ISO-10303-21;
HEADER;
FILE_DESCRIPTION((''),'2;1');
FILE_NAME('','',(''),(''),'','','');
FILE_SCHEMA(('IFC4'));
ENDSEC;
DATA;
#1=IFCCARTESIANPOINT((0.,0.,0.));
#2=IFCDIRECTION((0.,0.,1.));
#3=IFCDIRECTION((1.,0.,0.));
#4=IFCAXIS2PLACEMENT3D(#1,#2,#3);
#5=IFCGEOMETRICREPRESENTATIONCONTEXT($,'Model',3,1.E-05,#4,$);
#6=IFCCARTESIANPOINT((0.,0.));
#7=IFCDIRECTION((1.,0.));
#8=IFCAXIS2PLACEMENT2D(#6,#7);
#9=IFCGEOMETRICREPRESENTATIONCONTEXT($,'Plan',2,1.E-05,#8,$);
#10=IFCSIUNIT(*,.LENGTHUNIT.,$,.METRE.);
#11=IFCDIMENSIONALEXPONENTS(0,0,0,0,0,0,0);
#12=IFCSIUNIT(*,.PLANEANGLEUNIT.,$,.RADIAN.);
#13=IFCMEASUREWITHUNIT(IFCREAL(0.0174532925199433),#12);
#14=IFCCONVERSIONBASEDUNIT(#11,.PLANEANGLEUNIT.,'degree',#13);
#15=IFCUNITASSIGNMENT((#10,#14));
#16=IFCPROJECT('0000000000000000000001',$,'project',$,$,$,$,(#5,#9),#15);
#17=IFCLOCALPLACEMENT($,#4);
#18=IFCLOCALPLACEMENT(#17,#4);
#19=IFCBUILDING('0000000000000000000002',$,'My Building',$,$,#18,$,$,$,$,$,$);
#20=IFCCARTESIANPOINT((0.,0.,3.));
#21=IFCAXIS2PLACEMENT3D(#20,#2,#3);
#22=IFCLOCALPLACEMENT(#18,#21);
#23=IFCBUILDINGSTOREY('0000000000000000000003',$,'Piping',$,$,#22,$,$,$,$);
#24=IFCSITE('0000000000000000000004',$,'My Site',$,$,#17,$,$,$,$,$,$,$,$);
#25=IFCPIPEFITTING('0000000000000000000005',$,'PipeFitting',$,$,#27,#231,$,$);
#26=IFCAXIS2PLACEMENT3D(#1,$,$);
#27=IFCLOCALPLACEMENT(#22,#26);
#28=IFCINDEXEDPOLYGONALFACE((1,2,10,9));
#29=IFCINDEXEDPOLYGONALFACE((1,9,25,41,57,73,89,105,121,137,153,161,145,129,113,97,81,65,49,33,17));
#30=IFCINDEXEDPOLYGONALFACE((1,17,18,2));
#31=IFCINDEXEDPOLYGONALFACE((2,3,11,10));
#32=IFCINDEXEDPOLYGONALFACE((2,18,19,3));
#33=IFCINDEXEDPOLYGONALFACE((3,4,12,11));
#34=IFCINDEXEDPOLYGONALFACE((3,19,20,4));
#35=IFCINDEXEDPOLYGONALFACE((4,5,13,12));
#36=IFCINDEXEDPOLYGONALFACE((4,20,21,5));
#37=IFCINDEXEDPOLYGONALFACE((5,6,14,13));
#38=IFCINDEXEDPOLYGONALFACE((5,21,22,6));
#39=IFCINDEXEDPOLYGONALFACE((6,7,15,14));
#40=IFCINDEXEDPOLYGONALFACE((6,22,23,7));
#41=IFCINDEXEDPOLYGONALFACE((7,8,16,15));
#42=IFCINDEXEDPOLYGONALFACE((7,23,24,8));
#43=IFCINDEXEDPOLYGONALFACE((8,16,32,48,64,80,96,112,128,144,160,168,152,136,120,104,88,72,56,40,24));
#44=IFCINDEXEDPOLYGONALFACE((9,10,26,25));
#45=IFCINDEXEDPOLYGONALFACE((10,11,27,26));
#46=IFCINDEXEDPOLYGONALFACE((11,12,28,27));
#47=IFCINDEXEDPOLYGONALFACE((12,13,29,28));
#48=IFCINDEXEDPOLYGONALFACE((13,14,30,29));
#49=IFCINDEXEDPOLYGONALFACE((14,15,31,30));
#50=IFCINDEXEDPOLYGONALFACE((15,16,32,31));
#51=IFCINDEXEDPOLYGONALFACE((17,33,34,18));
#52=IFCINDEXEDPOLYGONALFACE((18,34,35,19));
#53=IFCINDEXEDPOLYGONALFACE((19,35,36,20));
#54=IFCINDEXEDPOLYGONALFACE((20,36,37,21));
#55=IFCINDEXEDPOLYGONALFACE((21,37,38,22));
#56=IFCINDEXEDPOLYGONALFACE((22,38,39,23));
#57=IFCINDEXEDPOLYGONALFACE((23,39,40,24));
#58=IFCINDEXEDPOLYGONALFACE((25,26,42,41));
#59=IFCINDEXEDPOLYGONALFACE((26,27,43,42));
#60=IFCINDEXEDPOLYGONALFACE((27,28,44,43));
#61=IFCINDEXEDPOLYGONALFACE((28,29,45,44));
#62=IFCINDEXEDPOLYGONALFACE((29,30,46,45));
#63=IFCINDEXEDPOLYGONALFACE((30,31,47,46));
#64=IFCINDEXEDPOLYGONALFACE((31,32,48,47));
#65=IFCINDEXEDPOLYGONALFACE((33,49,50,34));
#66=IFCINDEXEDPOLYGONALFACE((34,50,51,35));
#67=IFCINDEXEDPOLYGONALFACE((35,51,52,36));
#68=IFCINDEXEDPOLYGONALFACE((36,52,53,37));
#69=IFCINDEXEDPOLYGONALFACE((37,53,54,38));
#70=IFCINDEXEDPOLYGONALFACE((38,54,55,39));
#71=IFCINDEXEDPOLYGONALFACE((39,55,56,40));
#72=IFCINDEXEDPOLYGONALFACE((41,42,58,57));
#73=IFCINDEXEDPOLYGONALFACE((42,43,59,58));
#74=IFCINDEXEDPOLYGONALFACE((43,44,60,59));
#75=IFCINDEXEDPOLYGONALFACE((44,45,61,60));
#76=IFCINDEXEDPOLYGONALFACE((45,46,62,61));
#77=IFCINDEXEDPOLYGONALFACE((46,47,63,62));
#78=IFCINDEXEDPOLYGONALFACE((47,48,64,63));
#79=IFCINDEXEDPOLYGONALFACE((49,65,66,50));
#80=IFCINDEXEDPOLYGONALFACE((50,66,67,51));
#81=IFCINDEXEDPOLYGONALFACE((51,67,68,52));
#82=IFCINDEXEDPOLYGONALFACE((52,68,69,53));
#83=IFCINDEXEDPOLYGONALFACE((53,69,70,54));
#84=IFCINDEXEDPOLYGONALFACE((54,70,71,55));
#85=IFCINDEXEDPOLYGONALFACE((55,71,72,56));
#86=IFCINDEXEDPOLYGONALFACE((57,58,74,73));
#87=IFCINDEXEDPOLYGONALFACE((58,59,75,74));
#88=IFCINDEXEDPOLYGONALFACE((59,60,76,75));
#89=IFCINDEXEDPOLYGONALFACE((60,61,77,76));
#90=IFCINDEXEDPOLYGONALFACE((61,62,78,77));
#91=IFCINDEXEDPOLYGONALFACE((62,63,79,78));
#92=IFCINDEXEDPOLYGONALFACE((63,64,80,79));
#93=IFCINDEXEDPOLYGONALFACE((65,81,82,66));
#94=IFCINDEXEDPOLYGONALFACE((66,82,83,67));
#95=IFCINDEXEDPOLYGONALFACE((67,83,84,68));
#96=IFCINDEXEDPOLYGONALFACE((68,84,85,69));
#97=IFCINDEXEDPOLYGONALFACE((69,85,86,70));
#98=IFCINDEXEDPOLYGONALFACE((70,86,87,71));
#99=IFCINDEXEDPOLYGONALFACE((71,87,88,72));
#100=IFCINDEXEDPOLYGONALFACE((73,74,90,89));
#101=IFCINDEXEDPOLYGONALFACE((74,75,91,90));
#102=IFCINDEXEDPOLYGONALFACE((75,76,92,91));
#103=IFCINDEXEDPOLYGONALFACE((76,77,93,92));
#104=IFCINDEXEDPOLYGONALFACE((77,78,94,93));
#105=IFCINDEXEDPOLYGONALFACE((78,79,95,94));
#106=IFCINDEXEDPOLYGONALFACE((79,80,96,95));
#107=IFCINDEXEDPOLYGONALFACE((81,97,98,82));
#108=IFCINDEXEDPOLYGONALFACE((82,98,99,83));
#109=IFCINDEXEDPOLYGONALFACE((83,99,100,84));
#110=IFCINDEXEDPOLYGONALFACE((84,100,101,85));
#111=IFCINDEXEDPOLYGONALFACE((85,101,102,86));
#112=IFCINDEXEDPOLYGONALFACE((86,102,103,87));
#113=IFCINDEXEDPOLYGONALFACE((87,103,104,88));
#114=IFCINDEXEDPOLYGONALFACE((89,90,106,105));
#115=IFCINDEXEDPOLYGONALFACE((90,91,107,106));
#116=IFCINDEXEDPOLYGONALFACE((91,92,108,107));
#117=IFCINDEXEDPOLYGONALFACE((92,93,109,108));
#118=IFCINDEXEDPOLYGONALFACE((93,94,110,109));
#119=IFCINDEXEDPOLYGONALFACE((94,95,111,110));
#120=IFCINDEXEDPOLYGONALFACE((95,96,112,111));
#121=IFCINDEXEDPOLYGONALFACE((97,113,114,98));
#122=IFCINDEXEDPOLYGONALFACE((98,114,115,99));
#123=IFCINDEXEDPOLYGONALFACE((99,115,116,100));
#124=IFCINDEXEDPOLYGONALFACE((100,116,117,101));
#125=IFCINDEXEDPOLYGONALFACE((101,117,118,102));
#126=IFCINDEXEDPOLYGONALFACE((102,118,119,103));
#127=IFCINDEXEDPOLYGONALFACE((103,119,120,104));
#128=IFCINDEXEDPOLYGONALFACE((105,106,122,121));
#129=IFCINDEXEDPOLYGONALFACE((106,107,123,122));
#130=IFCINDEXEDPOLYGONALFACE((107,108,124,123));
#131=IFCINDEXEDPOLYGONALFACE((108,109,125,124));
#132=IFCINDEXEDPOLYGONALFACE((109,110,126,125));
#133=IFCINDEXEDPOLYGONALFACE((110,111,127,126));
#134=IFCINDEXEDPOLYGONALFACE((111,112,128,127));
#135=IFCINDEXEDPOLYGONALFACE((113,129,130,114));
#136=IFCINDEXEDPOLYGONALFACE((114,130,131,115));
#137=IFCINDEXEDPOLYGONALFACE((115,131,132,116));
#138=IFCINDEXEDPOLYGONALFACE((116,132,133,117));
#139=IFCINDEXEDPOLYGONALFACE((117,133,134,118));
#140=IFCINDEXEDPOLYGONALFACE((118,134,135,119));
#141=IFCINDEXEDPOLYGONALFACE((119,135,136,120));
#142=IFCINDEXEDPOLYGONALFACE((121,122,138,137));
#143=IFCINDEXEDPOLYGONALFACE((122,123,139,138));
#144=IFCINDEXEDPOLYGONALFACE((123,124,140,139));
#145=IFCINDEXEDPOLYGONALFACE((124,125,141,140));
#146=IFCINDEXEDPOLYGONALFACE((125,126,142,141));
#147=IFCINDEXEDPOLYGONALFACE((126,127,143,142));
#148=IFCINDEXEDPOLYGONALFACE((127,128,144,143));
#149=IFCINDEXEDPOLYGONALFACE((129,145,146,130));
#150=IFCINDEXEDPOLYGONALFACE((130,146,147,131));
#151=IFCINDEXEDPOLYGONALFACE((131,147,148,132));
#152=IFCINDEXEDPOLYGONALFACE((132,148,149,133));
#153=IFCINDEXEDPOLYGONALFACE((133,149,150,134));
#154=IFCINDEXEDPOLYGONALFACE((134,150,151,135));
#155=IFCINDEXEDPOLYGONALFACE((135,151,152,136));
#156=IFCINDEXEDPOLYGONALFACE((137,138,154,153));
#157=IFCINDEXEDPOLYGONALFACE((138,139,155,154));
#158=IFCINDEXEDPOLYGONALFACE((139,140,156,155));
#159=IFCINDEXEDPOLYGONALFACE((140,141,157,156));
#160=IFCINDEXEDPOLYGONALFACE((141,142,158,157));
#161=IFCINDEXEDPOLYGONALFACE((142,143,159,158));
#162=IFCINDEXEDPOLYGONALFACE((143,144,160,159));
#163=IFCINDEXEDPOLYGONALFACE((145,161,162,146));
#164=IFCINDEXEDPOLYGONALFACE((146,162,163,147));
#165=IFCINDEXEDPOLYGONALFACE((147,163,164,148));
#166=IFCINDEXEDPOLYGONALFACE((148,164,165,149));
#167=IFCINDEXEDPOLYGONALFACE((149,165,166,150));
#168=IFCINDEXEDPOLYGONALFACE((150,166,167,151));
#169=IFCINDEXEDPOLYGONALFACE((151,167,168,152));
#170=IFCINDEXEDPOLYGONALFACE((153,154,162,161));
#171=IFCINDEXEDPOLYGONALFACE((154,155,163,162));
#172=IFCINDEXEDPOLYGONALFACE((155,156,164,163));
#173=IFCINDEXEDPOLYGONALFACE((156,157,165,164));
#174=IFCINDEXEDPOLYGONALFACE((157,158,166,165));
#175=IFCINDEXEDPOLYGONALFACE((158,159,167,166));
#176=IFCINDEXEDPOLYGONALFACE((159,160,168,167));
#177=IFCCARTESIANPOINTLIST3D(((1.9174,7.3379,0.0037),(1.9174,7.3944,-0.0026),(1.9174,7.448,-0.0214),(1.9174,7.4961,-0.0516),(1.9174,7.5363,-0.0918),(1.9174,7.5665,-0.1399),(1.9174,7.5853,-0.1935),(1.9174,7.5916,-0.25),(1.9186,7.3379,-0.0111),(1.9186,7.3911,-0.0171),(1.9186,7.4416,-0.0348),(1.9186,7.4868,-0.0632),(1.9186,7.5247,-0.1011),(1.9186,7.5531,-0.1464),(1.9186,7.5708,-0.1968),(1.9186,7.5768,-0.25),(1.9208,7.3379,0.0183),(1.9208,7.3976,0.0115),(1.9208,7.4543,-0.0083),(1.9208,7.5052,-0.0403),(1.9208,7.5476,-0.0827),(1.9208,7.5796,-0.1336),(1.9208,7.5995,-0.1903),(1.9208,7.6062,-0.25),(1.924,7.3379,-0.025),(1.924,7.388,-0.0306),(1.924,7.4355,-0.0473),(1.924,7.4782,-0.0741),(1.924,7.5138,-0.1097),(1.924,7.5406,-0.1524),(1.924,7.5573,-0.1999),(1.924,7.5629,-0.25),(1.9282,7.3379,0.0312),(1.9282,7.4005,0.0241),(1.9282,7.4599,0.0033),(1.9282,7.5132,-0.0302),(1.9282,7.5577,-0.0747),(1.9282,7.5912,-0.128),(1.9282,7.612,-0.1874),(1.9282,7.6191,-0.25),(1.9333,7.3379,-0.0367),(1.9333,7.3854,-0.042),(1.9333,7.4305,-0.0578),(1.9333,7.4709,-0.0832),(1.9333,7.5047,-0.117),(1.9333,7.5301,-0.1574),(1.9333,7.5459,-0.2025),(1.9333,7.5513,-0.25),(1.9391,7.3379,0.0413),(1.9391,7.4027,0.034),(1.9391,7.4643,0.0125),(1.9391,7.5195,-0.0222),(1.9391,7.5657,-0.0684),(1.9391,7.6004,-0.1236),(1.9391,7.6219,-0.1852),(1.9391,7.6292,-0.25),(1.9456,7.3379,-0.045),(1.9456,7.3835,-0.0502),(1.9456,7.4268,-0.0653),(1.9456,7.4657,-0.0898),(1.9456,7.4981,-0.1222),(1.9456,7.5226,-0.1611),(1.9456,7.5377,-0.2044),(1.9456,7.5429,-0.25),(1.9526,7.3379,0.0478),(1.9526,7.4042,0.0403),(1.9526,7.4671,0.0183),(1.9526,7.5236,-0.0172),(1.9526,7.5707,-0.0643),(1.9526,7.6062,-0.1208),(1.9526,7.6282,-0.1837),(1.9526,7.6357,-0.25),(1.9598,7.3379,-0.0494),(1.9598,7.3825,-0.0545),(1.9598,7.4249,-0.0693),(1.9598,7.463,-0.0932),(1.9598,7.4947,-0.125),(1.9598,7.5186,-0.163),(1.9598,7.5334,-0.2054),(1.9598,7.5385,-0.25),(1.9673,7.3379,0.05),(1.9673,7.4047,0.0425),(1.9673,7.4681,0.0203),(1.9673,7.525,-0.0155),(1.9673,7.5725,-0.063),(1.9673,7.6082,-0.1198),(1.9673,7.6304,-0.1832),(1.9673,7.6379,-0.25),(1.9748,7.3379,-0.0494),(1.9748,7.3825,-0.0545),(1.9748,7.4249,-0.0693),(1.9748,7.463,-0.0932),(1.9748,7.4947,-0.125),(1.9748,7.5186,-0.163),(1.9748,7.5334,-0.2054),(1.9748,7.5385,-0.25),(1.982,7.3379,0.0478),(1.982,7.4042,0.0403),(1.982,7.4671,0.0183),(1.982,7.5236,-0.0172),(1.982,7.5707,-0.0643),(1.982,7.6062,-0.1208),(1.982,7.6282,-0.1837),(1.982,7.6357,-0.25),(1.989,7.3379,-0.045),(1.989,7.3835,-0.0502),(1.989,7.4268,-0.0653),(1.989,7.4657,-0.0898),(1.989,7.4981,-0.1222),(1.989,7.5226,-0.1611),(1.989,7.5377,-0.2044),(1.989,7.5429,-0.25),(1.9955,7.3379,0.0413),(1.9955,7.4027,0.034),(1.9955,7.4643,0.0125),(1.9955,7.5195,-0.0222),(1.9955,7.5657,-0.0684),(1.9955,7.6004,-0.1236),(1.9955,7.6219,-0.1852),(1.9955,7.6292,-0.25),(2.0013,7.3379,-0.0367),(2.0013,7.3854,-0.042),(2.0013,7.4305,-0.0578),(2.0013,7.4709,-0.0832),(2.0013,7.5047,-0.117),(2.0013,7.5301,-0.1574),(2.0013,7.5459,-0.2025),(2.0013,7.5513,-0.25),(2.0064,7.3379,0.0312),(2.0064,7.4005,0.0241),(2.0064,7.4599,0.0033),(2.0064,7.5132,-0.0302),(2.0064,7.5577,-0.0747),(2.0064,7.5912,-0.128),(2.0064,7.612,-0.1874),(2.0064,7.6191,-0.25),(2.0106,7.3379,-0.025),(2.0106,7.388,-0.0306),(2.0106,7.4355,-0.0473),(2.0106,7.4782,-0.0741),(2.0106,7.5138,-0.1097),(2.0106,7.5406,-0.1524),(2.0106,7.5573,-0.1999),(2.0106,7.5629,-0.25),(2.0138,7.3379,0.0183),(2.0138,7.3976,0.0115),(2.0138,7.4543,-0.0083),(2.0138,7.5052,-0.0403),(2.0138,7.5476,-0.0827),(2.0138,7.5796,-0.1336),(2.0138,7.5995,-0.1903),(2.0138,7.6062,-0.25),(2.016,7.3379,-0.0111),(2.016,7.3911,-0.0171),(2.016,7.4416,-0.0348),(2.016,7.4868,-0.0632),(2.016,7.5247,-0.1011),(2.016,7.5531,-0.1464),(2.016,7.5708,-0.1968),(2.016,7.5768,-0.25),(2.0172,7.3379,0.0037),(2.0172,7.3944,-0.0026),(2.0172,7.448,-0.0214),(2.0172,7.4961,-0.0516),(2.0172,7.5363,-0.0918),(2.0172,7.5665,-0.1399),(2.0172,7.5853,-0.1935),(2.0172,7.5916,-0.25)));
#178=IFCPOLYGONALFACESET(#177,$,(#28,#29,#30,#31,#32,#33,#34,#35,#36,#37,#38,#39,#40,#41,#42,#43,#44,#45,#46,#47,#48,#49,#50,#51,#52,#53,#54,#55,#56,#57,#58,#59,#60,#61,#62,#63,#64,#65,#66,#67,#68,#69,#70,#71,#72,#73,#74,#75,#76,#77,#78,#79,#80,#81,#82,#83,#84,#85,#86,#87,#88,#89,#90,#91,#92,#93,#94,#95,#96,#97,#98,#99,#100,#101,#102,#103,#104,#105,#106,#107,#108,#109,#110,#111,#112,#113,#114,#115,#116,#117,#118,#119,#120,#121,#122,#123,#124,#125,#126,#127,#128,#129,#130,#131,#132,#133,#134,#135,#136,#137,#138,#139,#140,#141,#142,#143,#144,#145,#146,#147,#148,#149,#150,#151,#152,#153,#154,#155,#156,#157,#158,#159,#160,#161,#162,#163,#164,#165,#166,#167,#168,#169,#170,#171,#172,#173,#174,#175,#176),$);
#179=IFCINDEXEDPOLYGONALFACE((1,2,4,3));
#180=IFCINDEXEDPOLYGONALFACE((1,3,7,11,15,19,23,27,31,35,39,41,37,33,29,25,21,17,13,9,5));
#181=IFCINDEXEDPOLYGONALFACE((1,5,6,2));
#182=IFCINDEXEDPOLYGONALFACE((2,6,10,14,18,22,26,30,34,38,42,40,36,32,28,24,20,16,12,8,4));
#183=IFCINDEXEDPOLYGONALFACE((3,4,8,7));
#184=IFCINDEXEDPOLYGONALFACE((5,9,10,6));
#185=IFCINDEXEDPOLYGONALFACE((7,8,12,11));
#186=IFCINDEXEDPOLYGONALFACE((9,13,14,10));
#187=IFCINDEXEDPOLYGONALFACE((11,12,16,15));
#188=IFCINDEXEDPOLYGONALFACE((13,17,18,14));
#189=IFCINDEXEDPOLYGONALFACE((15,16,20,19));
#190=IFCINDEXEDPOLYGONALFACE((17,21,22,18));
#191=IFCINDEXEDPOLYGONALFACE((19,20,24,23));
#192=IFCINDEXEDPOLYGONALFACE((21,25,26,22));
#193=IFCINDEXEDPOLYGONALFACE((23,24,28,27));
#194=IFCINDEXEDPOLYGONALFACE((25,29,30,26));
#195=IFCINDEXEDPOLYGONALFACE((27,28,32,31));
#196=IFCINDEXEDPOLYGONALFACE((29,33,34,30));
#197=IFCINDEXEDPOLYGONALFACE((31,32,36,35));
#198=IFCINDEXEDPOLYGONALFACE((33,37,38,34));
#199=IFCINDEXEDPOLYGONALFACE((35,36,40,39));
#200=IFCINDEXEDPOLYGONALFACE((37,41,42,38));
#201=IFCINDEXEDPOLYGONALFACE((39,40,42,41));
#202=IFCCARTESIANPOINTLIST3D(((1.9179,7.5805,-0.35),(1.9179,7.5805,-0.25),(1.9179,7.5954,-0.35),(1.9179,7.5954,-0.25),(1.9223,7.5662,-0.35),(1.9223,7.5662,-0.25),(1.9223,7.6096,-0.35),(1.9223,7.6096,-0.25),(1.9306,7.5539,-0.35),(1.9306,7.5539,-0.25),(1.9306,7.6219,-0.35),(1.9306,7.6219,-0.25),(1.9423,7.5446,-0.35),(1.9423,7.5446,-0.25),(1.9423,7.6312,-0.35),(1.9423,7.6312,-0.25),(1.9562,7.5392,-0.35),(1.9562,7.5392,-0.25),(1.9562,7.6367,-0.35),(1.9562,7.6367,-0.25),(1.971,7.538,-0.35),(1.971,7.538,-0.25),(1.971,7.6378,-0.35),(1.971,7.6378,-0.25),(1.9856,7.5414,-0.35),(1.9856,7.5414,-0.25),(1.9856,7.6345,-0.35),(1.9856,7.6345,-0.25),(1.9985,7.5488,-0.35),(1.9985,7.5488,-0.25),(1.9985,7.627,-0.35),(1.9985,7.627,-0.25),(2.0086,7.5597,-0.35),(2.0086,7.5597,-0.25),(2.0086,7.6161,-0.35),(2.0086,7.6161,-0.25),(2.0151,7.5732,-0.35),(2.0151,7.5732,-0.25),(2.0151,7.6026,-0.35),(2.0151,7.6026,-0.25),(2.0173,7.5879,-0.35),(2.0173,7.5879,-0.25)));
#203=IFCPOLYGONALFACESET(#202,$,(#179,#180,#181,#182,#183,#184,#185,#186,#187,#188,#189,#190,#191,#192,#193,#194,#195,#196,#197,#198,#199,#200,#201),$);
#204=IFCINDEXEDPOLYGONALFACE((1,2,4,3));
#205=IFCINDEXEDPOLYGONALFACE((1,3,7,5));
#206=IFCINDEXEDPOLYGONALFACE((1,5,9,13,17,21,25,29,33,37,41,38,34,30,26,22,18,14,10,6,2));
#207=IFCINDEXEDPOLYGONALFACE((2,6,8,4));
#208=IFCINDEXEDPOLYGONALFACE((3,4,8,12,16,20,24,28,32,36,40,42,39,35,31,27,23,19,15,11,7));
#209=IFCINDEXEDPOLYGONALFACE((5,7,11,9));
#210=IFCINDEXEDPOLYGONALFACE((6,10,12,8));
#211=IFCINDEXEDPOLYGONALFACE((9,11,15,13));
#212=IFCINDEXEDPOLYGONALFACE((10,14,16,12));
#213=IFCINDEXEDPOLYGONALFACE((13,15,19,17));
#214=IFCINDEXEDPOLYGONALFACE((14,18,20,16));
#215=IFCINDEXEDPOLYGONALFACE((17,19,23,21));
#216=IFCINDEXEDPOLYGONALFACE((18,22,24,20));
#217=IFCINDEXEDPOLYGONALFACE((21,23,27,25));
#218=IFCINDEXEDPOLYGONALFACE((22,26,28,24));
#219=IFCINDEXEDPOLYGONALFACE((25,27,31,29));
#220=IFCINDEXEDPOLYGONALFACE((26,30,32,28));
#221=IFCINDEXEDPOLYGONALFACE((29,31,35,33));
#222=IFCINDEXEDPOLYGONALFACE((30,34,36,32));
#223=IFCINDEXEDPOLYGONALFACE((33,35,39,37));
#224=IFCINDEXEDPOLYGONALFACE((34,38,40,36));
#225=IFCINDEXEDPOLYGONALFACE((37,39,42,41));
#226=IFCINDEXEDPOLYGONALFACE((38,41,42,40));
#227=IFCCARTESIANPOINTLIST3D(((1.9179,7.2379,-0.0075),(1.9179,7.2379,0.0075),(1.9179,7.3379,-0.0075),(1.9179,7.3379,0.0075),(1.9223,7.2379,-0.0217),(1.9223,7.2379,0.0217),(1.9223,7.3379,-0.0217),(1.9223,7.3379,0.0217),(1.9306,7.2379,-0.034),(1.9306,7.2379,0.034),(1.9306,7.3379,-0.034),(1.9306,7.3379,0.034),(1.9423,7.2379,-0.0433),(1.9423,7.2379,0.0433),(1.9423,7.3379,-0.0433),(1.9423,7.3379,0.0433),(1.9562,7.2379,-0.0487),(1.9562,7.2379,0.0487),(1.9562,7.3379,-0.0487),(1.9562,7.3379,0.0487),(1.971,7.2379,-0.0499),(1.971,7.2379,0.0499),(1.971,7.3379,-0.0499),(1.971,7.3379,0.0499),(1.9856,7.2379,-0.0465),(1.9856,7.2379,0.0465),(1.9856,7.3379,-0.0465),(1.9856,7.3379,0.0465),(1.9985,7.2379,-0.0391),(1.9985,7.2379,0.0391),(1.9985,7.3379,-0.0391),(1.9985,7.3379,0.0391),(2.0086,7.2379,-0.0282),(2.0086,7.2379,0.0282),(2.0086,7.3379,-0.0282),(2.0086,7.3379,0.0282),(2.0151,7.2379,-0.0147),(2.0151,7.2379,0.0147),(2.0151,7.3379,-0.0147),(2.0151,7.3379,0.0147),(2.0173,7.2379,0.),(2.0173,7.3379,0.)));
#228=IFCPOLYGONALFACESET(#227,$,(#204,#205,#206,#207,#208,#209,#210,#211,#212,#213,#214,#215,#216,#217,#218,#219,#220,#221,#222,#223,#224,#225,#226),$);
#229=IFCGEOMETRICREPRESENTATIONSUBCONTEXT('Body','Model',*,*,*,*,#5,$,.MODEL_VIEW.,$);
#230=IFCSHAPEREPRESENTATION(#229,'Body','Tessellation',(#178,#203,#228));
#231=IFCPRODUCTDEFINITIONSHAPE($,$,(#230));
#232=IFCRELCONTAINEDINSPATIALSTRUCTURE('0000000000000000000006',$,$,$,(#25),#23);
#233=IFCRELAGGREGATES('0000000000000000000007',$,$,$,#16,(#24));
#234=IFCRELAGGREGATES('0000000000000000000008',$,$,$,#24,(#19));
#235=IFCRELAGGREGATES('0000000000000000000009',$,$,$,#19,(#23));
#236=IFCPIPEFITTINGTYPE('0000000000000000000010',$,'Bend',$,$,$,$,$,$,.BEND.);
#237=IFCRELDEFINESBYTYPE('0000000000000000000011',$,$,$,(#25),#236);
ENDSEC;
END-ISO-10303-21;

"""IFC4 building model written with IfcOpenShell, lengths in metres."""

from ifc_helpers import new_model, entity, si_unit, converted_unit, frame, origin_with_axes, origin_2d_with_axis, place, context, subcontext, project, spatial, line, indexed_curve, circle, outline, extrude, source, transform, mapped, type_object, type_shapes, element, save


model = new_model("IFC4")

# Units and contexts
model_context = context("Model", 3, precision=1e-05, world=origin_with_axes())
plan_context = context("Plan", 2, precision=1e-05, world=origin_2d_with_axis())
body_context = subcontext(model_context, "Body", "Model", "MODEL_VIEW")
ifc_project = project(units=[si_unit("LENGTHUNIT", "METRE"), converted_unit("PLANEANGLEUNIT", "degree", entity("IfcReal", 0.0174532925199433), si_unit("PLANEANGLEUNIT", "RADIAN"), dimensions=[0, 0, 0, 0, 0, 0, 0])], contexts=[model_context, plan_context])

# Site, building, storey
site_placement = place(None, origin_with_axes())
site = spatial("IfcSite", under=ifc_project, at=site_placement, Name="My Site")
building_placement = place(site_placement, origin_with_axes())
building = spatial("IfcBuilding", under=site, at=building_placement, Name="My Building")
storey_placement = place(building_placement, frame((0.0, 0.0, 3.0), z_axis=(0.0, 0.0, 1.0), x_axis=(1.0, 0.0, 0.0)))
storey = spatial("IfcBuildingStorey", under=building, at=storey_placement, Name="Piping")

# Pipe fitting, opening
pipe_fitting_type = type_object("IfcPipeFittingType", Name="Bend", PredefinedType="BEND")
shared_shape = source(origin_with_axes(), body_context, "Body", "SolidModel", [
    entity("IfcSweptDiskSolid", entity("IfcIndexedPolyCurve", entity("IfcCartesianPointList3D", [[0.0, 0.0, -0.1], [0.0, 0.0732, -0.2768], [0.0, 0.25, -0.35]]), [entity("IfcArcIndex", [1, 2, 3])]), 0.05),
    extrude(circle(Radius=0.05), origin_with_axes(), (0.0, 0.0, -1.0), 0.1),
    extrude(circle(Radius=0.05), frame((0.0, 0.25, -0.35), z_axis=(0.0, 1.0, 0.0), x_axis=(1.0, 0.0, 0.0)), (0.0, 0.0, 1.0), 0.1),
])
type_shapes(pipe_fitting_type, [shared_shape])
pipe_fitting_1_placement = place(storey_placement, frame((1.9673, 7.5879, -0.35), z_axis=(0.0, 0.0, -1.0), x_axis=(1.0, 0.0, 0.0)))
pipe_fitting_1 = element("IfcPipeFitting", 1, at=pipe_fitting_1_placement, inside=storey, type_object=pipe_fitting_type, Name="PipeFitting", context=body_context, shape_type="MappedRepresentation", body=[
    mapped(shared_shape, transform((0.0, 0.0, 0.0), x_axis=(1.0, 0.0, 0.0), y_axis=(0.0, 1.0, 0.0), z_axis=(0.0, 0.0, 1.0), scale=1.0)),
])
opening_1_placement = place(pipe_fitting_1_placement, frame((1.9673, -1.5235, 2.65), z_axis=(0.0, 0.0, -1.0), x_axis=(-1.0, 0.0, 0.0)))
element("IfcOpeningElement", 2, at=opening_1_placement, cuts=pipe_fitting_1, PredefinedType="OPENING", context=body_context, shape_type="SweptSolid", body=[
    extrude(outline(indexed_curve([(0.0, 0.0), (0.5, 0.0), (0.5, 0.5), (0.0, 0.5)], segments=[line(1, 2, 3, 4, 1)])), origin_with_axes(), (0.0, 0.0, 1.0), 0.5),
])

save(model, "model.ifc")
